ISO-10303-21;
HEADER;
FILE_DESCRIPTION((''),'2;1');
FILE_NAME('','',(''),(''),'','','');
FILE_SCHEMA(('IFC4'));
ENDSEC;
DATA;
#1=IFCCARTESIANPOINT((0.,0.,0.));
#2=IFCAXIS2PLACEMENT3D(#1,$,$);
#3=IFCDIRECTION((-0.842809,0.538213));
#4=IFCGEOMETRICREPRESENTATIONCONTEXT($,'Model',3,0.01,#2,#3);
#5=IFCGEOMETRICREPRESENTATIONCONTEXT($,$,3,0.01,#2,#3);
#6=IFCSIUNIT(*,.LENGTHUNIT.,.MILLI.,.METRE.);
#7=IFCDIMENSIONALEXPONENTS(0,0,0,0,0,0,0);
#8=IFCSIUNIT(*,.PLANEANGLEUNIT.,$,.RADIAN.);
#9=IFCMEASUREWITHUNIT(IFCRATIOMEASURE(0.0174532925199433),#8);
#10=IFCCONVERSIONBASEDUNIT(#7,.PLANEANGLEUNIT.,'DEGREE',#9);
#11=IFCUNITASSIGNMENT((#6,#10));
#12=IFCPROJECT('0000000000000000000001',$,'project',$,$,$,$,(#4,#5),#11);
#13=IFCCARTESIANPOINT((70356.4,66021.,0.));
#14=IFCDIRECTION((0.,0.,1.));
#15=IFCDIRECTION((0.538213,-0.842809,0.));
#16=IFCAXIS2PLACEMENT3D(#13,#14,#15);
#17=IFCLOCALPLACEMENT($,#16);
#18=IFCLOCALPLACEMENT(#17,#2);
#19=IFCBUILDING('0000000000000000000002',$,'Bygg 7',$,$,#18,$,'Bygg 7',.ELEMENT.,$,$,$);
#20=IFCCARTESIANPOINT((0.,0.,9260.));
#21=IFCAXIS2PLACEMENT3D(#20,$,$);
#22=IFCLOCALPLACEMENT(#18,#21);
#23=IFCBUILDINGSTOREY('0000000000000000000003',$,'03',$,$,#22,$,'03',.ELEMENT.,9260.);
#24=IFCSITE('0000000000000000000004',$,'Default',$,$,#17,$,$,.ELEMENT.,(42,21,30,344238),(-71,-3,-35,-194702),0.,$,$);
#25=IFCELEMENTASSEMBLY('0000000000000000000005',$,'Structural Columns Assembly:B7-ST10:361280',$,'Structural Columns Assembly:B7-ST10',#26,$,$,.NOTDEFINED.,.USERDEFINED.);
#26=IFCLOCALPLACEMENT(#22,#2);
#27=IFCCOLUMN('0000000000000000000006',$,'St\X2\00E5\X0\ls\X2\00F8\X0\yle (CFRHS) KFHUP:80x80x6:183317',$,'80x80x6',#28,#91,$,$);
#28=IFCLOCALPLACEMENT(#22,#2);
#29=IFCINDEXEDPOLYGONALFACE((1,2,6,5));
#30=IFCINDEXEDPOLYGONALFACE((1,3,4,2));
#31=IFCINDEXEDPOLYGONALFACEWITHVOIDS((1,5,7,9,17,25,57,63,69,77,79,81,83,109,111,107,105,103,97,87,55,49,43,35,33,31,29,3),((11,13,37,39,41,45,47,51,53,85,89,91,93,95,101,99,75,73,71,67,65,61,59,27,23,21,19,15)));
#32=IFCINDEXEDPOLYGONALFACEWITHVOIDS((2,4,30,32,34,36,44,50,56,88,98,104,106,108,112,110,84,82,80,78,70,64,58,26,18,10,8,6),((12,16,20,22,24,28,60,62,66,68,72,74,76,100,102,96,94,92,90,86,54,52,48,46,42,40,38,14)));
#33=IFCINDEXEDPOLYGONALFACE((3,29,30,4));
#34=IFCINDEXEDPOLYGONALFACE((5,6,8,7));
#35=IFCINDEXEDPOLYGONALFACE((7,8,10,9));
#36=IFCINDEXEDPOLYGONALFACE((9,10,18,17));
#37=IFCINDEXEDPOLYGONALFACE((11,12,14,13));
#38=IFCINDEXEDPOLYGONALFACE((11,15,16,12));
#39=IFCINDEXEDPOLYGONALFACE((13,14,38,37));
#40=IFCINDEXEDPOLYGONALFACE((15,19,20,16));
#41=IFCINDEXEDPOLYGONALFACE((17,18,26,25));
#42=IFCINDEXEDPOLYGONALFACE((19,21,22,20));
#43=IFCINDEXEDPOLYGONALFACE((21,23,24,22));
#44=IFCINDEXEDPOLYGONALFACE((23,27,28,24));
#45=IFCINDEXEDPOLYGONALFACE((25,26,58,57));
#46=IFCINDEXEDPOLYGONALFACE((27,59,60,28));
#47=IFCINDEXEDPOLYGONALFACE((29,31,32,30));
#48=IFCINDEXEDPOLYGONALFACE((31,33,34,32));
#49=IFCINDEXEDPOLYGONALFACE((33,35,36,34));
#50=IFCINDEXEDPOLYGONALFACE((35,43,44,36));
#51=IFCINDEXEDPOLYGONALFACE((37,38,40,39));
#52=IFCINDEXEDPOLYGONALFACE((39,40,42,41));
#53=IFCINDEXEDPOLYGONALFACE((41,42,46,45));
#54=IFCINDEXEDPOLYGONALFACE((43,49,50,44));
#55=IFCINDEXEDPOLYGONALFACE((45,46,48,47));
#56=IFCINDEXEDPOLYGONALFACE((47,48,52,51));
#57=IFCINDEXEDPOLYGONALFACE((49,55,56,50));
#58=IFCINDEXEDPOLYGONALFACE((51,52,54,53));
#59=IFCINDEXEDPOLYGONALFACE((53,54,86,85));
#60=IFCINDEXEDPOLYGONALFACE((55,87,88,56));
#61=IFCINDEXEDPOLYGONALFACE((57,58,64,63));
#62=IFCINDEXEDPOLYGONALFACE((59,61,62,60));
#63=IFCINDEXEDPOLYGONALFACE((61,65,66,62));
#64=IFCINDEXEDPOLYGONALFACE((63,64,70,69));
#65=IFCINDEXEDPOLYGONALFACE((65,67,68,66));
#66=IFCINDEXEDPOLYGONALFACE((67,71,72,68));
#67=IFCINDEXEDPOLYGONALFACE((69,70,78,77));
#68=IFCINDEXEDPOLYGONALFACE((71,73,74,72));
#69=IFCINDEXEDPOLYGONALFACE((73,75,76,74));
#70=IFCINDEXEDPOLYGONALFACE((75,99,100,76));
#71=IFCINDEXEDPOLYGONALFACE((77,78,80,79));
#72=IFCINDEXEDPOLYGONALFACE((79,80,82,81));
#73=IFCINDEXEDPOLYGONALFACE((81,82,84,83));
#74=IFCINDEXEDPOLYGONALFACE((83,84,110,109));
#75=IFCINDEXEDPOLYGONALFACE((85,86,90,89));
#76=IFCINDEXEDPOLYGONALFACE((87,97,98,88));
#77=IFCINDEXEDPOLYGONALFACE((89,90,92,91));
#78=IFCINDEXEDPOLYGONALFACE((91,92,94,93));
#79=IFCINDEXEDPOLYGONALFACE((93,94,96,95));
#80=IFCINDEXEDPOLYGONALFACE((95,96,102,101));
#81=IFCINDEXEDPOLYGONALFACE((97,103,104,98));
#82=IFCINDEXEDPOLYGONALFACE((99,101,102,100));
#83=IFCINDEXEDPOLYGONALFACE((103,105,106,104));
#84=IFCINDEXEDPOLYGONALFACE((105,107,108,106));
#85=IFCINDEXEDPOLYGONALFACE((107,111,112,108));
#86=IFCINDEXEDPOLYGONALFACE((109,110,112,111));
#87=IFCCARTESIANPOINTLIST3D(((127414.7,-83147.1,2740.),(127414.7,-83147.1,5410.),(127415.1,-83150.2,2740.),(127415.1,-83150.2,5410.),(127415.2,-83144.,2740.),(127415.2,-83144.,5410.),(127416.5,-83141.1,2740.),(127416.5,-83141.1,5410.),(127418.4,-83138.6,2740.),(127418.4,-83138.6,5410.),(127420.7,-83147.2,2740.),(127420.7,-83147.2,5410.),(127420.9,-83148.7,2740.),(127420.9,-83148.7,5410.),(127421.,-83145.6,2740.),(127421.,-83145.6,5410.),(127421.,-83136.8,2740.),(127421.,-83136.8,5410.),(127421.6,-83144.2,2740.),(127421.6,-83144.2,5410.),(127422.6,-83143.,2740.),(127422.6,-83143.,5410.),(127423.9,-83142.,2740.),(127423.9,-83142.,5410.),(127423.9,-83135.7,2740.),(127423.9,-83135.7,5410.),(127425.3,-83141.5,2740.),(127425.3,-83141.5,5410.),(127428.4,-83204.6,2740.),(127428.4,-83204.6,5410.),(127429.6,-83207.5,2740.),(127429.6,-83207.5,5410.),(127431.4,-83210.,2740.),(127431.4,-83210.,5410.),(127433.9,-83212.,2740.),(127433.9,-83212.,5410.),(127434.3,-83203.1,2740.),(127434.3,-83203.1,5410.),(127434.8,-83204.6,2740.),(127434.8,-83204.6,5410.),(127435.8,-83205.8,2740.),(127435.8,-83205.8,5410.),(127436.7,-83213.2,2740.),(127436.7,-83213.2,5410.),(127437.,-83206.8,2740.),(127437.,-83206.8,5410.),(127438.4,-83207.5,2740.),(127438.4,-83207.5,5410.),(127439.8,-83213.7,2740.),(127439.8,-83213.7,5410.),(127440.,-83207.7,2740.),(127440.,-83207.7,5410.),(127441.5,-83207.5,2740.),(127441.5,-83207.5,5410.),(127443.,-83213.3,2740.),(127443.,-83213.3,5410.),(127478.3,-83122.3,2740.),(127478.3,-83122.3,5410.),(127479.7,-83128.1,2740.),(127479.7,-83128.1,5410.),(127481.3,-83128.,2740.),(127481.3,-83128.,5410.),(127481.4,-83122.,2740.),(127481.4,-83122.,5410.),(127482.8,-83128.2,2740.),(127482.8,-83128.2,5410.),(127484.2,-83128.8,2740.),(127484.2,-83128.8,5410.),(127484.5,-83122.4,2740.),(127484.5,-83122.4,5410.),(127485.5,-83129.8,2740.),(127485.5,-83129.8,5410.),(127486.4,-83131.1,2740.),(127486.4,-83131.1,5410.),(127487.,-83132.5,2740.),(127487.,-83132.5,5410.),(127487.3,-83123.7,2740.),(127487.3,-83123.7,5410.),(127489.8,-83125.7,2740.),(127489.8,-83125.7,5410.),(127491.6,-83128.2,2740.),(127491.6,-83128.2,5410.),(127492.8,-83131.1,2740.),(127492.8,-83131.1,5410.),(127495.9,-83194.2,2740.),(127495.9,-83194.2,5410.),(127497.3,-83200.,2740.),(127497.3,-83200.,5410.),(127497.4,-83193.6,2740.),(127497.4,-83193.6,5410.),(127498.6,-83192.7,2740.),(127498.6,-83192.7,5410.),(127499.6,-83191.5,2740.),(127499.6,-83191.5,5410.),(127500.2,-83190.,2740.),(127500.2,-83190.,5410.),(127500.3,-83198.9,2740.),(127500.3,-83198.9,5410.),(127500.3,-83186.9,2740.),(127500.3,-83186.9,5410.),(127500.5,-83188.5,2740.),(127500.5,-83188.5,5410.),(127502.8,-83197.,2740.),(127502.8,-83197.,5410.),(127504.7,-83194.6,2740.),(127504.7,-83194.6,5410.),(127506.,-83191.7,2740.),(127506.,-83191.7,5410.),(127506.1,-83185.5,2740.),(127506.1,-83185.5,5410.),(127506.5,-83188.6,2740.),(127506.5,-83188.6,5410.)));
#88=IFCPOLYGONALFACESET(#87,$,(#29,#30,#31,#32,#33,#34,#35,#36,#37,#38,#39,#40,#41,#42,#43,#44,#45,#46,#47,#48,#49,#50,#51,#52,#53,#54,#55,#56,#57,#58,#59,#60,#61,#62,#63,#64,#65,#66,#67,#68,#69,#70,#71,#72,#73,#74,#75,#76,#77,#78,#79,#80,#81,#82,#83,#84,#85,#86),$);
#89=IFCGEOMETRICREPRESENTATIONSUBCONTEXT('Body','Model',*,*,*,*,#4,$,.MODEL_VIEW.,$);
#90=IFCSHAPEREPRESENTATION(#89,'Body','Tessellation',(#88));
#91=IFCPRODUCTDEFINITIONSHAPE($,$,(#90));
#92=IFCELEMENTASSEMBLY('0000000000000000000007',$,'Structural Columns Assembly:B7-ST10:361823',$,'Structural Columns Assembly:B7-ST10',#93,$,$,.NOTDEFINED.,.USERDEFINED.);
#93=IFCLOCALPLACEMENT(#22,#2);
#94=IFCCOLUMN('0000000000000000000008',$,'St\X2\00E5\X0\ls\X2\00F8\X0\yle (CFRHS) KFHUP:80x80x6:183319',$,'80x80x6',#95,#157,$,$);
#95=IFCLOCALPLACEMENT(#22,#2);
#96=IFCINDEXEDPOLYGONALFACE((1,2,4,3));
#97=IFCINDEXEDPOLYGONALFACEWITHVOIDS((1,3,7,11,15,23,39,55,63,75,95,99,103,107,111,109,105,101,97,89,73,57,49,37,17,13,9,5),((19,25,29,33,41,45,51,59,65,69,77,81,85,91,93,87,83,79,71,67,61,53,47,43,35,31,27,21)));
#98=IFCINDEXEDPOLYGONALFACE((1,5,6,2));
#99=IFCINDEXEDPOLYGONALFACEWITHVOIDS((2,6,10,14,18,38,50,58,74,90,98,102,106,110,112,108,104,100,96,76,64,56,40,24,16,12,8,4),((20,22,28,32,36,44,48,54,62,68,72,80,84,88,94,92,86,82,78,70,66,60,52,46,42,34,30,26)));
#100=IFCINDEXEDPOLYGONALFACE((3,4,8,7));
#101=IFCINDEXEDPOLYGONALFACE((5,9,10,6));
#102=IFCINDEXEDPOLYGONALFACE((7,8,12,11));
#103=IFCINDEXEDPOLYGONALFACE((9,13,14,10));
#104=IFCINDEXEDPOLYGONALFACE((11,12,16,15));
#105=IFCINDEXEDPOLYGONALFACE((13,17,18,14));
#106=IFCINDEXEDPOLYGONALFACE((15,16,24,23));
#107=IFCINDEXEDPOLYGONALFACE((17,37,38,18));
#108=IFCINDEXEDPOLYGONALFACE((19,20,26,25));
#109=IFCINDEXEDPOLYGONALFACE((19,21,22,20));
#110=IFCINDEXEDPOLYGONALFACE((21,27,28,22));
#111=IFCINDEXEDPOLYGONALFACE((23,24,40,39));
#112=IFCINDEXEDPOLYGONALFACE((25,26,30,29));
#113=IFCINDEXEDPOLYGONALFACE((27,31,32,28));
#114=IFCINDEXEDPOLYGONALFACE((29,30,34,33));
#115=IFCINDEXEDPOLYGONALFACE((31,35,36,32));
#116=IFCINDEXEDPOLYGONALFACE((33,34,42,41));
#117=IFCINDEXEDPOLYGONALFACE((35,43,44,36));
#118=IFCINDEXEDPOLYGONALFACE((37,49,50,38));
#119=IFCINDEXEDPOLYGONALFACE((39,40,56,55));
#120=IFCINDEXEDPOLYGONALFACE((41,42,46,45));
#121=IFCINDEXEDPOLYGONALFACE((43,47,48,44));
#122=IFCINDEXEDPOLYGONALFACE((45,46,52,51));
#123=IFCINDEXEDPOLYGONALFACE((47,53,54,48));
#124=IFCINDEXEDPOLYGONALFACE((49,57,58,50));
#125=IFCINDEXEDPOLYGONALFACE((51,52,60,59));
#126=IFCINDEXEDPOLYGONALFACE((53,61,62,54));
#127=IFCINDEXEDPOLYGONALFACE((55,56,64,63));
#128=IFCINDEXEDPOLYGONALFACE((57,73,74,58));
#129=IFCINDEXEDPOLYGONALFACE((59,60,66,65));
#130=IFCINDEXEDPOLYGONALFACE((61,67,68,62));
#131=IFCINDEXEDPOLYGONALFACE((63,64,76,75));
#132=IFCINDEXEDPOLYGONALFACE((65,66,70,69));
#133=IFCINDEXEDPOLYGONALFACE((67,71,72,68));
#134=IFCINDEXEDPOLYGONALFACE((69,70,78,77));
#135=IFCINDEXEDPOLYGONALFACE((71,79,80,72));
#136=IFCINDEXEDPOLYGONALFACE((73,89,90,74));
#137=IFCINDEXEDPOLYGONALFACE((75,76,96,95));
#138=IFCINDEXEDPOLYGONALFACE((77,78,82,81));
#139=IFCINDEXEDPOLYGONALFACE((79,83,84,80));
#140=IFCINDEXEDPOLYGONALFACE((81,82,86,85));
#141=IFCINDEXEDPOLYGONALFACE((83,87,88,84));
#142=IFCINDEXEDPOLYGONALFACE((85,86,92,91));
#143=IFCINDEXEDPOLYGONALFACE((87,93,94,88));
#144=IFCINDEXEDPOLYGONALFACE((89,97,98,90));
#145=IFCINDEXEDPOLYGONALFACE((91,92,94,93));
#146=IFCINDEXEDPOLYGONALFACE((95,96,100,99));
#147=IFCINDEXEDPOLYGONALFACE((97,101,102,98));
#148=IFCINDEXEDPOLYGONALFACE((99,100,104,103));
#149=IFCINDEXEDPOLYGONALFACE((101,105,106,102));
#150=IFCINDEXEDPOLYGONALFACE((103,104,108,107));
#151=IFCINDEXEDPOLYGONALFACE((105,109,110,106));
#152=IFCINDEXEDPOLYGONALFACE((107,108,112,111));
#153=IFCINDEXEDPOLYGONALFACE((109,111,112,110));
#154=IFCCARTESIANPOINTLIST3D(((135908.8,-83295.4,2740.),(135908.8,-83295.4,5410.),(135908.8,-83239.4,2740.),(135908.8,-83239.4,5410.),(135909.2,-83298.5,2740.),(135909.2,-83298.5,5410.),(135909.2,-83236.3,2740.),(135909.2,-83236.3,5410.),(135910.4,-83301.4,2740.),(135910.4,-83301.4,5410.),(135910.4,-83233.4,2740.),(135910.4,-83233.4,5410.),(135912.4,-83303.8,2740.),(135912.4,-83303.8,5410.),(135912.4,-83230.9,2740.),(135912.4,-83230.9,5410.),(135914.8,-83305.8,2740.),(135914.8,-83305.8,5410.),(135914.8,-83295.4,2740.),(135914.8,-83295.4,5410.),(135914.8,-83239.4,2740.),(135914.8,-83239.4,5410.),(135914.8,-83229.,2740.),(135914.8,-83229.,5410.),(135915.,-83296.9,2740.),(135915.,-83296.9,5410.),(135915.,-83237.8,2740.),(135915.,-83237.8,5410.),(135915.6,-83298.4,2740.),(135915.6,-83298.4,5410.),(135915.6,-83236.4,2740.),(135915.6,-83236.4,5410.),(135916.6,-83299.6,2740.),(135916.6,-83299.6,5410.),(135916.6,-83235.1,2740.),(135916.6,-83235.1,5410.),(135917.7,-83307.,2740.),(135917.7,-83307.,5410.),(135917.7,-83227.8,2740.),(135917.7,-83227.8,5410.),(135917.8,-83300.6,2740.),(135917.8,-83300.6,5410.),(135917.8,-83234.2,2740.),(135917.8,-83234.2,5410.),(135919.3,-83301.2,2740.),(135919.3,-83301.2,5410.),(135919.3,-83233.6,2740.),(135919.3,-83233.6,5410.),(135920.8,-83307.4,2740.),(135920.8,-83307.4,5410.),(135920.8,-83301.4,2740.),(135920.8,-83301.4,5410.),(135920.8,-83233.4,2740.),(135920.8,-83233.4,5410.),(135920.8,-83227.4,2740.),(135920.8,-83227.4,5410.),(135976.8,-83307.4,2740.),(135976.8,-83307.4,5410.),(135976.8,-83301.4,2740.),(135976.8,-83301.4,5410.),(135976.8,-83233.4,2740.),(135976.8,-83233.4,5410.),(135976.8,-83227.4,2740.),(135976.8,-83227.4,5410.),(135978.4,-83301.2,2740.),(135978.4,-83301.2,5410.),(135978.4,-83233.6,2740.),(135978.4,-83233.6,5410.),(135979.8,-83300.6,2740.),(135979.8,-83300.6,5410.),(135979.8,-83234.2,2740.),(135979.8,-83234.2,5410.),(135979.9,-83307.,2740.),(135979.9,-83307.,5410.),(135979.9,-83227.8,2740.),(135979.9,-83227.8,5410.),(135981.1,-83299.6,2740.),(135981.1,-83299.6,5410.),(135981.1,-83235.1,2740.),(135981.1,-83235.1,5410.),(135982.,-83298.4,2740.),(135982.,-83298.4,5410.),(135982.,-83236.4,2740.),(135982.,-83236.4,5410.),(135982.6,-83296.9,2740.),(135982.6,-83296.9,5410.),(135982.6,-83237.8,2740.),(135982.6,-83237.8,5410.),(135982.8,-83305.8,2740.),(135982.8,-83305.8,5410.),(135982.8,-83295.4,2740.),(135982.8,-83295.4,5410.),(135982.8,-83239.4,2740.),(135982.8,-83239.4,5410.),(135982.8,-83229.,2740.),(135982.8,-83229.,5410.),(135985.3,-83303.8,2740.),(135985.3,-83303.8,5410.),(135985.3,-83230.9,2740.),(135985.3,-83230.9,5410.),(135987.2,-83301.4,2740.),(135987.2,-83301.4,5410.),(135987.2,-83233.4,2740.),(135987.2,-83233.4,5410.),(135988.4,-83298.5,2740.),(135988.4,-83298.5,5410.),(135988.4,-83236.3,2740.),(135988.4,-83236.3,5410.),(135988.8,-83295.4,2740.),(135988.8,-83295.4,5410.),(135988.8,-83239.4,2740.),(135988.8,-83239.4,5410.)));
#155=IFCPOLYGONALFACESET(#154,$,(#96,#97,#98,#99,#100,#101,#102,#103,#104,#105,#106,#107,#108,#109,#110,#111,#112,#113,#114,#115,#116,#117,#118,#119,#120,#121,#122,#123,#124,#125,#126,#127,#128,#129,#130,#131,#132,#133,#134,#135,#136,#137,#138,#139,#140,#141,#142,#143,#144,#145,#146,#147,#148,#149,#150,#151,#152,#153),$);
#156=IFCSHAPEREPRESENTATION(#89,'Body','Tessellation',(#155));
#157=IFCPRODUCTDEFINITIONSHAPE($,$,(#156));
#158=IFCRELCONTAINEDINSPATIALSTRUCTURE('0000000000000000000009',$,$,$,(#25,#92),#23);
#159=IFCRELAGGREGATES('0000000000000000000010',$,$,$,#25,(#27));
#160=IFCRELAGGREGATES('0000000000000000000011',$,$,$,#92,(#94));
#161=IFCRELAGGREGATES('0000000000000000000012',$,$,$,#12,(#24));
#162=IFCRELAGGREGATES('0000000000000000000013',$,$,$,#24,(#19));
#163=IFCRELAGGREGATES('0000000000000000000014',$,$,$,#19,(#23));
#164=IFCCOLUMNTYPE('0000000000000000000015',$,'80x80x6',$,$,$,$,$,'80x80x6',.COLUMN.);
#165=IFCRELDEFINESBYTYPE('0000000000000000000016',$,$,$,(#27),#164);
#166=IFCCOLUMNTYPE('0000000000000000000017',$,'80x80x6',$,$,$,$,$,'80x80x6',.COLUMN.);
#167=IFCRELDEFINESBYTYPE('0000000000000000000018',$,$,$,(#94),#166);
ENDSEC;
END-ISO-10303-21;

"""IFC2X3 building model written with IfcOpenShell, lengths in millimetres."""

from ifc_helpers import new_model, entity, si_unit, converted_unit, direction, frame, frame_2d, origin, place, context, subcontext, project, spatial, polyline, circle_curve, parameter, trimmed, segment, composite_curve, outline, extrude, source, transform, mapped, type_object, type_shapes, element, aggregate, save


model = new_model("IFC2X3")

# Units and contexts
model_context = context("Model", 3, precision=0.01, world=origin(), true_north=direction((-0.842809, 0.538213)))
context_of_model = context(None, 3, precision=0.01, world=origin(), true_north=direction((-0.842809, 0.538213)))
body_context = subcontext(model_context, "Body", "Model", "MODEL_VIEW")
ifc_project = project(units=[si_unit("LENGTHUNIT", "METRE", prefix="MILLI"), converted_unit("PLANEANGLEUNIT", "DEGREE", entity("IfcRatioMeasure", 0.0174532925199433), si_unit("PLANEANGLEUNIT", "RADIAN"), dimensions=[0, 0, 0, 0, 0, 0, 0])], contexts=[model_context, context_of_model])

# Site, building, storey
site_placement = place(None, frame((70356.4, 66021.0, 0.0), z_axis=(0.0, 0.0, 1.0), x_axis=(0.538213, -0.842809, 0.0)))
site = spatial("IfcSite", under=ifc_project, at=site_placement, Name="Default", CompositionType="ELEMENT", RefLatitude=(42, 21, 30, 344238), RefLongitude=(-71, -3, -35, -194702), RefElevation=0.0)
building_placement = place(site_placement, origin())
building = spatial("IfcBuilding", under=site, at=building_placement, Name="Bygg 7", LongName="Bygg 7", CompositionType="ELEMENT")
storey_placement = place(building_placement, frame((0.0, 0.0, 9260.0)))
storey = spatial("IfcBuildingStorey", under=building, at=storey_placement, Name="03", LongName="03", CompositionType="ELEMENT", Elevation=9260.0)

# Element assemblies, columns
assembly_1_placement = place(storey_placement, origin())
assembly_1 = element("IfcElementAssembly", 1, at=assembly_1_placement, inside=storey, Name="Structural Columns Assembly:B7-ST10:361280", ObjectType="Structural Columns Assembly:B7-ST10", AssemblyPlace="NOTDEFINED", PredefinedType="USERDEFINED")
column_type_1 = type_object("IfcColumnType", Name="80x80x6", ElementType="80x80x6", PredefinedType="COLUMN")
shared_shape_1 = source(origin(), body_context, "Body", "SweptSolid", [
    extrude(outline(composite_curve([segment(trimmed(circle_curve(frame_2d((-28.0, 28.0), x_axis=(1.0, 0.0)), 12.0), [parameter(90.0)], [parameter(180.0)], True, "PARAMETER"), True, "CONTINUOUS"), segment(polyline([(-40.0, 28.0), (-40.0, -28.0)]), True, "CONTINUOUS"), segment(trimmed(circle_curve(frame_2d((-28.0, -28.0), x_axis=(1.0, 0.0)), 12.0), [parameter(180.0)], [parameter(270.0)], True, "PARAMETER"), True, "CONTINUOUS"), segment(polyline([(-28.0, -40.0), (28.0, -40.0)]), True, "CONTINUOUS"), segment(trimmed(circle_curve(frame_2d((28.0, -28.0), x_axis=(1.0, 0.0)), 12.0), [parameter(270.0)], [parameter(0.0)], True, "PARAMETER"), True, "CONTINUOUS"), segment(polyline([(40.0, -28.0), (40.0, 28.0)]), True, "CONTINUOUS"), segment(trimmed(circle_curve(frame_2d((28.0, 28.0), x_axis=(1.0, 0.0)), 12.0), [parameter(0.0)], [parameter(90.0)], True, "PARAMETER"), True, "CONTINUOUS"), segment(polyline([(28.0, 40.0), (-28.0, 40.0)]), True, "CONTINUOUS")], self_intersect=False), holes=[composite_curve([segment(polyline([(-28.0, 34.0), (28.0, 34.0)]), True, "CONTINUOUS"), segment(trimmed(circle_curve(frame_2d((28.0, 28.0), x_axis=(1.0, 0.0)), 6.0), [parameter(360.0)], [parameter(90.0)], True, "PARAMETER"), False, "CONTINUOUS"), segment(polyline([(34.0, 28.0), (34.0, -28.0)]), True, "CONTINUOUS"), segment(trimmed(circle_curve(frame_2d((28.0, -28.0), x_axis=(1.0, 0.0)), 6.0), [parameter(270.0)], [parameter(360.0)], True, "PARAMETER"), False, "CONTINUOUS"), segment(polyline([(28.0, -34.0), (-28.0, -34.0)]), True, "CONTINUOUS"), segment(trimmed(circle_curve(frame_2d((-28.0, -28.0), x_axis=(1.0, 0.0)), 6.0), [parameter(180.0)], [parameter(270.0)], True, "PARAMETER"), False, "CONTINUOUS"), segment(polyline([(-34.0, -28.0), (-34.0, 28.0)]), True, "CONTINUOUS"), segment(trimmed(circle_curve(frame_2d((-28.0, 28.0), x_axis=(1.0, 0.0)), 6.0), [parameter(90.0)], [parameter(180.0)], True, "PARAMETER"), False, "CONTINUOUS")], self_intersect=False)]), frame((47.5, 47.5, 0.0), z_axis=(0.0, 0.0, 1.0), x_axis=(-0.971172, -0.238381, 0.0)), (0.0, 0.0, 1.0), 2670.0),
])
type_shapes(column_type_1, [shared_shape_1])
column_1_placement = place(assembly_1_placement, frame((127413.1, -83215.3, 2740.0)))
column_1 = element("IfcColumn", 2, at=column_1_placement, type_object=column_type_1, Name="Stålsøyle (CFRHS) KFHUP:80x80x6:183317", ObjectType="80x80x6", context=body_context, shape_type="MappedRepresentation", body=[
    mapped(shared_shape_1, transform((0.0, 0.0, 0.0), scale=1.0)),
])
aggregate(assembly_1, [column_1])
assembly_2_placement = place(storey_placement, origin())
assembly_2 = element("IfcElementAssembly", 3, at=assembly_2_placement, inside=storey, Name="Structural Columns Assembly:B7-ST10:361823", ObjectType="Structural Columns Assembly:B7-ST10", AssemblyPlace="NOTDEFINED", PredefinedType="USERDEFINED")
column_type_2 = type_object("IfcColumnType", Name="80x80x6", ElementType="80x80x6", PredefinedType="COLUMN")
shared_shape_2 = source(origin(), body_context, "Body", "SweptSolid", [
    extrude(outline(composite_curve([segment(trimmed(circle_curve(frame_2d((-28.0, 28.0), x_axis=(1.0, 0.0)), 12.0), [parameter(90.0)], [parameter(180.0)], True, "PARAMETER"), True, "CONTINUOUS"), segment(polyline([(-40.0, 28.0), (-40.0, -28.0)]), True, "CONTINUOUS"), segment(trimmed(circle_curve(frame_2d((-28.0, -28.0), x_axis=(1.0, 0.0)), 12.0), [parameter(180.0)], [parameter(270.0)], True, "PARAMETER"), True, "CONTINUOUS"), segment(polyline([(-28.0, -40.0), (28.0, -40.0)]), True, "CONTINUOUS"), segment(trimmed(circle_curve(frame_2d((28.0, -28.0), x_axis=(1.0, 0.0)), 12.0), [parameter(270.0)], [parameter(0.0)], True, "PARAMETER"), True, "CONTINUOUS"), segment(polyline([(40.0, -28.0), (40.0, 28.0)]), True, "CONTINUOUS"), segment(trimmed(circle_curve(frame_2d((28.0, 28.0), x_axis=(1.0, 0.0)), 12.0), [parameter(0.0)], [parameter(90.0)], True, "PARAMETER"), True, "CONTINUOUS"), segment(polyline([(28.0, 40.0), (-28.0, 40.0)]), True, "CONTINUOUS")], self_intersect=False), holes=[composite_curve([segment(polyline([(-28.0, 34.0), (28.0, 34.0)]), True, "CONTINUOUS"), segment(trimmed(circle_curve(frame_2d((28.0, 28.0), x_axis=(1.0, 0.0)), 6.0), [parameter(360.0)], [parameter(90.0)], True, "PARAMETER"), False, "CONTINUOUS"), segment(polyline([(34.0, 28.0), (34.0, -28.0)]), True, "CONTINUOUS"), segment(trimmed(circle_curve(frame_2d((28.0, -28.0), x_axis=(1.0, 0.0)), 6.0), [parameter(270.0)], [parameter(360.0)], True, "PARAMETER"), False, "CONTINUOUS"), segment(polyline([(28.0, -34.0), (-28.0, -34.0)]), True, "CONTINUOUS"), segment(trimmed(circle_curve(frame_2d((-28.0, -28.0), x_axis=(1.0, 0.0)), 6.0), [parameter(180.0)], [parameter(270.0)], True, "PARAMETER"), False, "CONTINUOUS"), segment(polyline([(-34.0, -28.0), (-34.0, 28.0)]), True, "CONTINUOUS"), segment(trimmed(circle_curve(frame_2d((-28.0, 28.0), x_axis=(1.0, 0.0)), 6.0), [parameter(90.0)], [parameter(180.0)], True, "PARAMETER"), False, "CONTINUOUS")], self_intersect=False)]), frame((41.6, 41.6, 0.0), z_axis=(0.0, 0.0, 1.0), x_axis=(0.0, -1.0, 0.0)), (0.0, 0.0, 1.0), 2670.0),
])
type_shapes(column_type_2, [shared_shape_2])
column_2_placement = place(assembly_2_placement, frame((135907.2, -83309.0, 2740.0)))
column_2 = element("IfcColumn", 4, at=column_2_placement, type_object=column_type_2, Name="Stålsøyle (CFRHS) KFHUP:80x80x6:183319", ObjectType="80x80x6", context=body_context, shape_type="MappedRepresentation", body=[
    mapped(shared_shape_2, transform((0.0, 0.0, 0.0), scale=1.0)),
])
aggregate(assembly_2, [column_2])

save(model, "model.ifc")
